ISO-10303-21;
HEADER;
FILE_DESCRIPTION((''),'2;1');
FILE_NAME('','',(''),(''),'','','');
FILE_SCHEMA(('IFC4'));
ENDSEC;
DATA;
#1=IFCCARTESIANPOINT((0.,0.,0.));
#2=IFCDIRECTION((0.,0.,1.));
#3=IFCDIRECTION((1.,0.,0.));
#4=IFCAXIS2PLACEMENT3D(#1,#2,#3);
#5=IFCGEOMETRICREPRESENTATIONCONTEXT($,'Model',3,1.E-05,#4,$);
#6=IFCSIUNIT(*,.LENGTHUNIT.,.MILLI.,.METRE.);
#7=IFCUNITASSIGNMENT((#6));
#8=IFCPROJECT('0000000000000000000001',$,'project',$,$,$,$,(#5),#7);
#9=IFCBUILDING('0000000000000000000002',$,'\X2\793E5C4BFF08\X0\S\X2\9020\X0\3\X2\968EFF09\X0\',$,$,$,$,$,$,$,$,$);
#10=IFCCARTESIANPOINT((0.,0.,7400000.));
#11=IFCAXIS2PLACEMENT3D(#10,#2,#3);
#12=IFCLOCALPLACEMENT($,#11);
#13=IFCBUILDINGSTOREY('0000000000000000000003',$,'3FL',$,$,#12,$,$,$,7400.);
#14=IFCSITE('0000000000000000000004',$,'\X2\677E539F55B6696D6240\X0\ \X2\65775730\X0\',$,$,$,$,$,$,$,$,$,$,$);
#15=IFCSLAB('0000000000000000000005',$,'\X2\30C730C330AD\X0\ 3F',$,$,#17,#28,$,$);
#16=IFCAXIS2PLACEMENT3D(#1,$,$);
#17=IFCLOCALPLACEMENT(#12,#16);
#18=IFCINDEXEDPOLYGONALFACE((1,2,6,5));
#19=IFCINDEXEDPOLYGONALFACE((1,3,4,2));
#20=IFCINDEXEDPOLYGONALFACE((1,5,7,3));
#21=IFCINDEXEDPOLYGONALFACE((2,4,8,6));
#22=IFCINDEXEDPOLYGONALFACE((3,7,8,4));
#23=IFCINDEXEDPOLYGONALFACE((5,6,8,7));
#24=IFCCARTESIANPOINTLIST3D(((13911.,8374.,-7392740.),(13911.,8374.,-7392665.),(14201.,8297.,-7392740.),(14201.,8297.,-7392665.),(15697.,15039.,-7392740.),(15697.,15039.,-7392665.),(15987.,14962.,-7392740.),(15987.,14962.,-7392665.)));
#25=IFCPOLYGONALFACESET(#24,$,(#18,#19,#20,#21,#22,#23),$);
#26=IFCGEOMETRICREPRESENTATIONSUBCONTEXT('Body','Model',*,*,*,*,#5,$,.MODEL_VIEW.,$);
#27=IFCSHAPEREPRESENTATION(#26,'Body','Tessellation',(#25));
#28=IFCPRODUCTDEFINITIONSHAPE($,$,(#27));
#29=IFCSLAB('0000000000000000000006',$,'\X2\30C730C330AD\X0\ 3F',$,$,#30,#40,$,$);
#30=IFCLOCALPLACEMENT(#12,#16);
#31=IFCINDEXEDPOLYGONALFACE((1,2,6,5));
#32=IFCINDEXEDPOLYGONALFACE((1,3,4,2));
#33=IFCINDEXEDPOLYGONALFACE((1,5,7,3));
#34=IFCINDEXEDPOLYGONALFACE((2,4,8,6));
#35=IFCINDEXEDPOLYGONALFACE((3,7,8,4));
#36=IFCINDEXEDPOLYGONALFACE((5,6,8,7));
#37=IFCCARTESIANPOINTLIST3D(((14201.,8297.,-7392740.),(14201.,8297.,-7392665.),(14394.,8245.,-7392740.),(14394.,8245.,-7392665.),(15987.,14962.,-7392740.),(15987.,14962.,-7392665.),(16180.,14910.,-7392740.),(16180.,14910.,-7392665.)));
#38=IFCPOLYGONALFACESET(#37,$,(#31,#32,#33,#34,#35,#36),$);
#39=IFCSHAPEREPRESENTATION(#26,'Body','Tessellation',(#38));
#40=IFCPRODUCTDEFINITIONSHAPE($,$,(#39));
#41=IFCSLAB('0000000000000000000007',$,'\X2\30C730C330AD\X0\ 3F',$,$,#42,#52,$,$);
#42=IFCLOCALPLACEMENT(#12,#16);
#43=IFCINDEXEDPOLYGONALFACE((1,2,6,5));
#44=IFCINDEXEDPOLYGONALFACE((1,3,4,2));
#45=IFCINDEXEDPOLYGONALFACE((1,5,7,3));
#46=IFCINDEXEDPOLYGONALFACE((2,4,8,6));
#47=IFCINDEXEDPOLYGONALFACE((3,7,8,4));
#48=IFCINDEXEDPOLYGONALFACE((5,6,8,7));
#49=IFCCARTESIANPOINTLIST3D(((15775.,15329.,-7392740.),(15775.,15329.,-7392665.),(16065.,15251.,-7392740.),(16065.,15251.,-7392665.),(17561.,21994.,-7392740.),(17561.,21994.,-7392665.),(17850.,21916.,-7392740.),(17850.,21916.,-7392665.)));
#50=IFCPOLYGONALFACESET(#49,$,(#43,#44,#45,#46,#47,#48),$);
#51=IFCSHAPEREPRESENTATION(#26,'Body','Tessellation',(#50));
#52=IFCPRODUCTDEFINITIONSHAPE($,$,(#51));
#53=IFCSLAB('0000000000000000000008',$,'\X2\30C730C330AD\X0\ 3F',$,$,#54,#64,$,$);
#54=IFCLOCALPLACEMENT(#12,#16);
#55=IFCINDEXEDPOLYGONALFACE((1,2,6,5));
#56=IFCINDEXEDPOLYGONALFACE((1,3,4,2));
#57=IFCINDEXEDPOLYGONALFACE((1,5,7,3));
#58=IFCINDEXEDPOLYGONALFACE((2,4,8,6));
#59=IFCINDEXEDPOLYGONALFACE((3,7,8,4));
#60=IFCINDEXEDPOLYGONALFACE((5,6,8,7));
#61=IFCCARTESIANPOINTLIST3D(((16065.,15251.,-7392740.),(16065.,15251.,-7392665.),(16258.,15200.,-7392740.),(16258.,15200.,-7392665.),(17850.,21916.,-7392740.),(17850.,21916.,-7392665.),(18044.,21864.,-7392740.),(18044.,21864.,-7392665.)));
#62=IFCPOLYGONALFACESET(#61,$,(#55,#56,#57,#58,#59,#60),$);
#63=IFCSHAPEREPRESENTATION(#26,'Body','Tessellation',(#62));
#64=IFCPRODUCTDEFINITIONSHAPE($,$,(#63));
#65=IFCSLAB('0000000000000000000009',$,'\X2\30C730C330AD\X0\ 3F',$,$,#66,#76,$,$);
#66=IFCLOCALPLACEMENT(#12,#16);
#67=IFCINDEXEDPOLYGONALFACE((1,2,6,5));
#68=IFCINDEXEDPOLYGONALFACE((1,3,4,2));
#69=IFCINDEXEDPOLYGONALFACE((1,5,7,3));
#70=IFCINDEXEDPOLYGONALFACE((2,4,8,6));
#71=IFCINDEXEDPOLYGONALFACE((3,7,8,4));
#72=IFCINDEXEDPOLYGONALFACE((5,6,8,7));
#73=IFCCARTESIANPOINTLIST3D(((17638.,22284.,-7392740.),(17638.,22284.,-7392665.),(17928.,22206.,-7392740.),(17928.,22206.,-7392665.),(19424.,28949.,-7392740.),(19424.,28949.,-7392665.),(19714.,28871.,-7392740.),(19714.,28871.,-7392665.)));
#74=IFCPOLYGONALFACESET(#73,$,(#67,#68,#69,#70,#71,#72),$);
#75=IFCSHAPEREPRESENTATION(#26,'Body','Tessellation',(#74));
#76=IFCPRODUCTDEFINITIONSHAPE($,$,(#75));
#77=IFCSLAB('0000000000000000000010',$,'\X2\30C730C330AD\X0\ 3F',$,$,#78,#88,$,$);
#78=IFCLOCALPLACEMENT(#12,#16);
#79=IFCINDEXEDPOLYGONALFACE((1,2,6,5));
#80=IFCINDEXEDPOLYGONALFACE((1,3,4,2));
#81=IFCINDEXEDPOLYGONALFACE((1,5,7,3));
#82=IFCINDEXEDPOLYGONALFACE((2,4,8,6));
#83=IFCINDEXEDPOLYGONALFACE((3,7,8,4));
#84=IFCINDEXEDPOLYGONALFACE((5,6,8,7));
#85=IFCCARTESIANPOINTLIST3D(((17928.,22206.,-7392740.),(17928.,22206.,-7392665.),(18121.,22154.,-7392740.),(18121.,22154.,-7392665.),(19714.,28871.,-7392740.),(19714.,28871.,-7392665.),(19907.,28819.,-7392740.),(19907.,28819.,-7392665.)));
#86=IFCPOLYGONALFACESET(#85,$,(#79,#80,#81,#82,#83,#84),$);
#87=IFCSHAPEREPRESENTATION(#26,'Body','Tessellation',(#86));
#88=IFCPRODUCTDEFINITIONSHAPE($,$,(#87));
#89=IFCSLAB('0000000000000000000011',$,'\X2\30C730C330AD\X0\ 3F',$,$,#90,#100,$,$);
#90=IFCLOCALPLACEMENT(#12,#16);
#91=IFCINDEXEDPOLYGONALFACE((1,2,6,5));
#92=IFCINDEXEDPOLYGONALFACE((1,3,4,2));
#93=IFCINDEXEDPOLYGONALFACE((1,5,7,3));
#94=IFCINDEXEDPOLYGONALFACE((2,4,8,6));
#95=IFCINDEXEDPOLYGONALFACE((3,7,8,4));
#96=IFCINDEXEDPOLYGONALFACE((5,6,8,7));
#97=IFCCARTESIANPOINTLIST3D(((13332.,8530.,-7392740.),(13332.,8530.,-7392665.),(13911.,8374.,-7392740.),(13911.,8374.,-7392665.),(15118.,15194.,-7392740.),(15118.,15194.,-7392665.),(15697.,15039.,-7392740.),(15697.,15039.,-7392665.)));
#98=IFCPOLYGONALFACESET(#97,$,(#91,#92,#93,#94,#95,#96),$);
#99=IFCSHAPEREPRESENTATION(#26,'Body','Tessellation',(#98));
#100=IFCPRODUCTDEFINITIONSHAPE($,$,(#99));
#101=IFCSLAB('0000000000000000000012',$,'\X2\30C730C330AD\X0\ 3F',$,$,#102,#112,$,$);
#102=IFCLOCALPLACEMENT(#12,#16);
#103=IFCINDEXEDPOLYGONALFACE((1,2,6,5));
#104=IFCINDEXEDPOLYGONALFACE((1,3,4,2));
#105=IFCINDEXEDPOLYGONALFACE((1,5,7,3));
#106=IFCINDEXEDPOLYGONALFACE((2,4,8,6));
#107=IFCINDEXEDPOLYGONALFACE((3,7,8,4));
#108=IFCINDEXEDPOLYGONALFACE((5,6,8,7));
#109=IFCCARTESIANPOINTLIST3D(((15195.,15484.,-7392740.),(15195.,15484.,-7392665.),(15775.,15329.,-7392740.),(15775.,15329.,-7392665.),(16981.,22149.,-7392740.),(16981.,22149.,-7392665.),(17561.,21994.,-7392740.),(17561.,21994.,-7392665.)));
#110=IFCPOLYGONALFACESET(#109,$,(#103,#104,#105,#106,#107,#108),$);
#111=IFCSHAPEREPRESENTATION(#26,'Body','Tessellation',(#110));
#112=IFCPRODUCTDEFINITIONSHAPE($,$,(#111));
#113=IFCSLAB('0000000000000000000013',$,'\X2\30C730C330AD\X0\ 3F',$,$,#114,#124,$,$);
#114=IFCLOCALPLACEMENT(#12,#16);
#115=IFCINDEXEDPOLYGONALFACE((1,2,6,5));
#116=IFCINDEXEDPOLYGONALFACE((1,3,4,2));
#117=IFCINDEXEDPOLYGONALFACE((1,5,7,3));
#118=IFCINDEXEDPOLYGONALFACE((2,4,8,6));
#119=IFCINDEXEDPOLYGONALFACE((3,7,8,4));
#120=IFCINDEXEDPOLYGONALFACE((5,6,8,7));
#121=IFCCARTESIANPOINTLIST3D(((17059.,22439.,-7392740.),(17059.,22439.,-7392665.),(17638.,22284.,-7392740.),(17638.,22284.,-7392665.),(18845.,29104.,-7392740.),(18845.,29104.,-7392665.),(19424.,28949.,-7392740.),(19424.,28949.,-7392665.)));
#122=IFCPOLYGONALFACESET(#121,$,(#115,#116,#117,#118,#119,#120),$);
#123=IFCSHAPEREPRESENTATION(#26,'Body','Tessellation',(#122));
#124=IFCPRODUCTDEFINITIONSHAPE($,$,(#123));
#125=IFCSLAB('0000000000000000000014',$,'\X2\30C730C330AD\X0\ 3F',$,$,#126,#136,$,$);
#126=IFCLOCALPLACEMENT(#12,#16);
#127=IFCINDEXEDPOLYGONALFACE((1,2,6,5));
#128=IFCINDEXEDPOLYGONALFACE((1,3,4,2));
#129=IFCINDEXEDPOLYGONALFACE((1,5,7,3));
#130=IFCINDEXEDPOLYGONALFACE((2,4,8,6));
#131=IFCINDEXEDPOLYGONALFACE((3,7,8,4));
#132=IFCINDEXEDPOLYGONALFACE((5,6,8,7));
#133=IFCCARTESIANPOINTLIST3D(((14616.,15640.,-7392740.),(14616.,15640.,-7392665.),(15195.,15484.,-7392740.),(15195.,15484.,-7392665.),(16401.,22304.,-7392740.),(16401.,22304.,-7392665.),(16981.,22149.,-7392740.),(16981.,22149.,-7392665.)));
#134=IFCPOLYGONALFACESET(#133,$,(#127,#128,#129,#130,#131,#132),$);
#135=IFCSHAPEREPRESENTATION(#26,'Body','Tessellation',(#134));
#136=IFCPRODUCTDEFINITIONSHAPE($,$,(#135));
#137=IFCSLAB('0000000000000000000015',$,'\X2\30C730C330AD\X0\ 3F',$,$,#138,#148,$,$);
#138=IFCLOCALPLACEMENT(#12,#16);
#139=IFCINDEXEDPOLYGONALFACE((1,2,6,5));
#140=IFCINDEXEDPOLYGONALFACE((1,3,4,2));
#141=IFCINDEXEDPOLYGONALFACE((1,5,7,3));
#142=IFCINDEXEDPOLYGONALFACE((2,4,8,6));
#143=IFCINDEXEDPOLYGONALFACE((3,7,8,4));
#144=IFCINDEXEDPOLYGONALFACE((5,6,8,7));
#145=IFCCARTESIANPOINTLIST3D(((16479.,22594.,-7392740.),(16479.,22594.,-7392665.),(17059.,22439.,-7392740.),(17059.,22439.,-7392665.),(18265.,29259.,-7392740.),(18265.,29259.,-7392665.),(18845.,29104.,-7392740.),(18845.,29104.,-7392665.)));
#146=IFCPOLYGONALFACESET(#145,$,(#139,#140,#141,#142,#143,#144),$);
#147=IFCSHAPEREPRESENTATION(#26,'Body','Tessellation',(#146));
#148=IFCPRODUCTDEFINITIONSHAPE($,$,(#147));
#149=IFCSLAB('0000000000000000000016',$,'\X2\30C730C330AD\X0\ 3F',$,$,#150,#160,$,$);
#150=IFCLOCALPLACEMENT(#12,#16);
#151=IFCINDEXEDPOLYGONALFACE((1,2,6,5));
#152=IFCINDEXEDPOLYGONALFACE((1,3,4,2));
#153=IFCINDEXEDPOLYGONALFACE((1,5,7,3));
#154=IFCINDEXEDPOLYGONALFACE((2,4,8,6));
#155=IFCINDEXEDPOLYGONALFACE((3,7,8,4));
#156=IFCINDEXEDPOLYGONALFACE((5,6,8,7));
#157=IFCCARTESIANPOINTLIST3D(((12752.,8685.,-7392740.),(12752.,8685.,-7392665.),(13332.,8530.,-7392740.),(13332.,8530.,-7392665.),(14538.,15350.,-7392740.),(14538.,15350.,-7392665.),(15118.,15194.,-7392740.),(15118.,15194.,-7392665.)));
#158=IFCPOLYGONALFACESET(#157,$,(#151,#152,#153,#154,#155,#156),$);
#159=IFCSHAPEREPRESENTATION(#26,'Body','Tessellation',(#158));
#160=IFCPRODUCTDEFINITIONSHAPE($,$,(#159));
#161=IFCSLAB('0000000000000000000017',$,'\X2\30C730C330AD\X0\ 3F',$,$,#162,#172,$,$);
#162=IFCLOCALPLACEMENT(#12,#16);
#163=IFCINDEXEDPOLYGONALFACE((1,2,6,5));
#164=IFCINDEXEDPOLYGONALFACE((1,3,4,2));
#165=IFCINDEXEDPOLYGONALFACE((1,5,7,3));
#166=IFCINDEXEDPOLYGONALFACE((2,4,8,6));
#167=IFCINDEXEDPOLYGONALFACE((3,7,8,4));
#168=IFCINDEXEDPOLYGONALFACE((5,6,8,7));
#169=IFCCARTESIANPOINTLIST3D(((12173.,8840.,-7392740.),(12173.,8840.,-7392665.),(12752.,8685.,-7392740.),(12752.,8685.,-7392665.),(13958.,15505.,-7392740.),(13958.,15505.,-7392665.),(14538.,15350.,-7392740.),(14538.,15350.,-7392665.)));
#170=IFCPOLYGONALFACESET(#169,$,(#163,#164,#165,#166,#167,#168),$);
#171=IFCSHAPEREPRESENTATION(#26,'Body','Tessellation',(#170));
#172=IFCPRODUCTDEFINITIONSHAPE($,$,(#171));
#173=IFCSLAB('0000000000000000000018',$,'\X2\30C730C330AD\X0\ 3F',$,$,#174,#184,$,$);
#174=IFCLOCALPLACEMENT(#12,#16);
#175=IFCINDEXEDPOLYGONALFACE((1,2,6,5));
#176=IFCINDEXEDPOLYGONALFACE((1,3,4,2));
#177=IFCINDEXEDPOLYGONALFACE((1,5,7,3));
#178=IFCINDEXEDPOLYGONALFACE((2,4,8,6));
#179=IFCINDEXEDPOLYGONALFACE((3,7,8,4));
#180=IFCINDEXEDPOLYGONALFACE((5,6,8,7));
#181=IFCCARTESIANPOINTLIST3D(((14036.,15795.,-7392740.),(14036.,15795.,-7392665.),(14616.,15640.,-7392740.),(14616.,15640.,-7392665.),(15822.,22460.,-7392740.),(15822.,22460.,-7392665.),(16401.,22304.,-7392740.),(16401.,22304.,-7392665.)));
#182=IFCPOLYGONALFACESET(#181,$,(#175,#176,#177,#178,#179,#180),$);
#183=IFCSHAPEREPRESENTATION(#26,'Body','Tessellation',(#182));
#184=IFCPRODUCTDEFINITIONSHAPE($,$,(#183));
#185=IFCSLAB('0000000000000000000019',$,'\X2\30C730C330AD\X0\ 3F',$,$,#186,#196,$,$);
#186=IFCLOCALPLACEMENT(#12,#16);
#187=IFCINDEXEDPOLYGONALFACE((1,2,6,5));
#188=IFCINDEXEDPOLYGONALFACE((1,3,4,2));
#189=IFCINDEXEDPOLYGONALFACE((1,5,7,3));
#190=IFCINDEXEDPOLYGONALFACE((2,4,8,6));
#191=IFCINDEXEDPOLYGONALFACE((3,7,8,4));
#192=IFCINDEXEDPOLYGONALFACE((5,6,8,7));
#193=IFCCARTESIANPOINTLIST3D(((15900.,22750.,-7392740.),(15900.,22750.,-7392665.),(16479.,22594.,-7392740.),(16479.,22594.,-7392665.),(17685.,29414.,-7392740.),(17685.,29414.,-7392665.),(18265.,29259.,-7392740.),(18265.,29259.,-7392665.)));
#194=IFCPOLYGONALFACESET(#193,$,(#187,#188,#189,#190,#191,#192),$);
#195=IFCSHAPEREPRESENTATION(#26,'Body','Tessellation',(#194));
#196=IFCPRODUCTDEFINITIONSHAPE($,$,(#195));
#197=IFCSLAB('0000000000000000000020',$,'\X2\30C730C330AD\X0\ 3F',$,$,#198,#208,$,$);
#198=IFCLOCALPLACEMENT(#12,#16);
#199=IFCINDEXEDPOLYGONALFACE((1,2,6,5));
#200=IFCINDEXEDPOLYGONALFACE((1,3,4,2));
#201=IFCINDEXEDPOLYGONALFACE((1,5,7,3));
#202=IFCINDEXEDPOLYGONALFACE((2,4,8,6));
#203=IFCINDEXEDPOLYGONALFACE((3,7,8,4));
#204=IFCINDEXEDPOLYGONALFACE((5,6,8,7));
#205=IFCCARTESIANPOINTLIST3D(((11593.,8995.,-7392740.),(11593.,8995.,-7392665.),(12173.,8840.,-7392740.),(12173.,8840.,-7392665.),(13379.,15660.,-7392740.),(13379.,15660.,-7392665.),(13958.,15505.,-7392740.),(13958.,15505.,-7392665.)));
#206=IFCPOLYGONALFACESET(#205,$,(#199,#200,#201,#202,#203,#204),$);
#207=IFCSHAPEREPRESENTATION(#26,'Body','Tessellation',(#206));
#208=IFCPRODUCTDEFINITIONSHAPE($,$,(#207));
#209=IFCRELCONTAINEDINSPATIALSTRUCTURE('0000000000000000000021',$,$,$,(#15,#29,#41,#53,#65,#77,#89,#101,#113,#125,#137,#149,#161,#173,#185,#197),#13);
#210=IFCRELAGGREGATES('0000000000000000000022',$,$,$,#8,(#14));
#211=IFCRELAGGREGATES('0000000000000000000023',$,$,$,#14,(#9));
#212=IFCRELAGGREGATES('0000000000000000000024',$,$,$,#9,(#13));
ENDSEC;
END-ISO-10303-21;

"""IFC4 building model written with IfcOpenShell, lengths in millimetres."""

from ifc_helpers import new_model, si_unit, frame, origin, origin_with_axes, place, context, subcontext, project, spatial, polyline, outline, extrude, element, save


model = new_model("IFC4")

# Units and contexts
model_context = context("Model", 3, precision=1e-05, world=origin_with_axes())
body_context = subcontext(model_context, "Body", "Model", "MODEL_VIEW")
ifc_project = project(units=[si_unit("LENGTHUNIT", "METRE", prefix="MILLI")], contexts=[model_context])

# Site, building, storey
site = spatial("IfcSite", under=ifc_project, Name="松原営業所 敷地")
building = spatial("IfcBuilding", under=site, Name="社屋（S造3階）")
storey_placement = place(None, frame((0.0, 0.0, 7400000.0), z_axis=(0.0, 0.0, 1.0), x_axis=(1.0, 0.0, 0.0)))
storey = spatial("IfcBuildingStorey", under=building, at=storey_placement, Name="3FL", Elevation=7400.0)

# Slabs
slab_1_placement = place(storey_placement, frame((0.0, 0.0, -7392740.0), z_axis=(0.0, 0.0, 1.0), x_axis=(1.0, 0.0, 0.0)))
element("IfcSlab", 1, at=slab_1_placement, inside=storey, Name="デッキ 3F", context=body_context, shape_type="SweptSolid", body=[
    extrude(outline(polyline([(14201.0, 8297.0), (15987.0, 14962.0), (15697.0, 15039.0), (13911.0, 8374.0), (14201.0, 8297.0)])), origin(), (0.0, 0.0, 1.0), 75.0),
])
slab_2_placement = place(storey_placement, frame((0.0, 0.0, -7392740.0), z_axis=(0.0, 0.0, 1.0), x_axis=(1.0, 0.0, 0.0)))
element("IfcSlab", 2, at=slab_2_placement, inside=storey, Name="デッキ 3F", context=body_context, shape_type="SweptSolid", body=[
    extrude(outline(polyline([(14201.0, 8297.0), (15987.0, 14962.0), (16180.0, 14910.0), (14394.0, 8245.0), (14201.0, 8297.0)])), origin(), (0.0, 0.0, 1.0), 75.0),
])
slab_3_placement = place(storey_placement, frame((0.0, 0.0, -7392740.0), z_axis=(0.0, 0.0, 1.0), x_axis=(1.0, 0.0, 0.0)))
element("IfcSlab", 3, at=slab_3_placement, inside=storey, Name="デッキ 3F", context=body_context, shape_type="SweptSolid", body=[
    extrude(outline(polyline([(16065.0, 15251.0), (17850.0, 21916.0), (17561.0, 21994.0), (15775.0, 15329.0), (16065.0, 15251.0)])), origin(), (0.0, 0.0, 1.0), 75.0),
])
slab_4_placement = place(storey_placement, frame((0.0, 0.0, -7392740.0), z_axis=(0.0, 0.0, 1.0), x_axis=(1.0, 0.0, 0.0)))
element("IfcSlab", 4, at=slab_4_placement, inside=storey, Name="デッキ 3F", context=body_context, shape_type="SweptSolid", body=[
    extrude(outline(polyline([(16065.0, 15251.0), (17850.0, 21916.0), (18044.0, 21864.0), (16258.0, 15200.0), (16065.0, 15251.0)])), origin(), (0.0, 0.0, 1.0), 75.0),
])
slab_5_placement = place(storey_placement, frame((0.0, 0.0, -7392740.0), z_axis=(0.0, 0.0, 1.0), x_axis=(1.0, 0.0, 0.0)))
element("IfcSlab", 5, at=slab_5_placement, inside=storey, Name="デッキ 3F", context=body_context, shape_type="SweptSolid", body=[
    extrude(outline(polyline([(17928.0, 22206.0), (19714.0, 28871.0), (19424.0, 28949.0), (17638.0, 22284.0), (17928.0, 22206.0)])), origin(), (0.0, 0.0, 1.0), 75.0),
])
slab_6_placement = place(storey_placement, frame((0.0, 0.0, -7392740.0), z_axis=(0.0, 0.0, 1.0), x_axis=(1.0, 0.0, 0.0)))
element("IfcSlab", 6, at=slab_6_placement, inside=storey, Name="デッキ 3F", context=body_context, shape_type="SweptSolid", body=[
    extrude(outline(polyline([(17928.0, 22206.0), (19714.0, 28871.0), (19907.0, 28819.0), (18121.0, 22154.0), (17928.0, 22206.0)])), origin(), (0.0, 0.0, 1.0), 75.0),
])
slab_7_placement = place(storey_placement, frame((0.0, 0.0, -7392740.0), z_axis=(0.0, 0.0, 1.0), x_axis=(1.0, 0.0, 0.0)))
element("IfcSlab", 7, at=slab_7_placement, inside=storey, Name="デッキ 3F", context=body_context, shape_type="SweptSolid", body=[
    extrude(outline(polyline([(13911.0, 8374.0), (15697.0, 15039.0), (15118.0, 15194.0), (13332.0, 8530.0), (13911.0, 8374.0)])), origin(), (0.0, 0.0, 1.0), 75.0),
])
slab_8_placement = place(storey_placement, frame((0.0, 0.0, -7392740.0), z_axis=(0.0, 0.0, 1.0), x_axis=(1.0, 0.0, 0.0)))
element("IfcSlab", 8, at=slab_8_placement, inside=storey, Name="デッキ 3F", context=body_context, shape_type="SweptSolid", body=[
    extrude(outline(polyline([(15775.0, 15329.0), (17561.0, 21994.0), (16981.0, 22149.0), (15195.0, 15484.0), (15775.0, 15329.0)])), origin(), (0.0, 0.0, 1.0), 75.0),
])
slab_9_placement = place(storey_placement, frame((0.0, 0.0, -7392740.0), z_axis=(0.0, 0.0, 1.0), x_axis=(1.0, 0.0, 0.0)))
element("IfcSlab", 9, at=slab_9_placement, inside=storey, Name="デッキ 3F", context=body_context, shape_type="SweptSolid", body=[
    extrude(outline(polyline([(17638.0, 22284.0), (19424.0, 28949.0), (18845.0, 29104.0), (17059.0, 22439.0), (17638.0, 22284.0)])), origin(), (0.0, 0.0, 1.0), 75.0),
])
slab_10_placement = place(storey_placement, frame((0.0, 0.0, -7392740.0), z_axis=(0.0, 0.0, 1.0), x_axis=(1.0, 0.0, 0.0)))
element("IfcSlab", 10, at=slab_10_placement, inside=storey, Name="デッキ 3F", context=body_context, shape_type="SweptSolid", body=[
    extrude(outline(polyline([(15195.0, 15484.0), (16981.0, 22149.0), (16401.0, 22304.0), (14616.0, 15640.0), (15195.0, 15484.0)])), origin(), (0.0, 0.0, 1.0), 75.0),
])
slab_11_placement = place(storey_placement, frame((0.0, 0.0, -7392740.0), z_axis=(0.0, 0.0, 1.0), x_axis=(1.0, 0.0, 0.0)))
element("IfcSlab", 11, at=slab_11_placement, inside=storey, Name="デッキ 3F", context=body_context, shape_type="SweptSolid", body=[
    extrude(outline(polyline([(17059.0, 22439.0), (18845.0, 29104.0), (18265.0, 29259.0), (16479.0, 22594.0), (17059.0, 22439.0)])), origin(), (0.0, 0.0, 1.0), 75.0),
])
slab_12_placement = place(storey_placement, frame((0.0, 0.0, -7392740.0), z_axis=(0.0, 0.0, 1.0), x_axis=(1.0, 0.0, 0.0)))
element("IfcSlab", 12, at=slab_12_placement, inside=storey, Name="デッキ 3F", context=body_context, shape_type="SweptSolid", body=[
    extrude(outline(polyline([(13332.0, 8530.0), (15118.0, 15194.0), (14538.0, 15350.0), (12752.0, 8685.0), (13332.0, 8530.0)])), origin(), (0.0, 0.0, 1.0), 75.0),
])
slab_13_placement = place(storey_placement, frame((0.0, 0.0, -7392740.0), z_axis=(0.0, 0.0, 1.0), x_axis=(1.0, 0.0, 0.0)))
element("IfcSlab", 13, at=slab_13_placement, inside=storey, Name="デッキ 3F", context=body_context, shape_type="SweptSolid", body=[
    extrude(outline(polyline([(12752.0, 8685.0), (14538.0, 15350.0), (13958.0, 15505.0), (12173.0, 8840.0), (12752.0, 8685.0)])), origin(), (0.0, 0.0, 1.0), 75.0),
])
slab_14_placement = place(storey_placement, frame((0.0, 0.0, -7392740.0), z_axis=(0.0, 0.0, 1.0), x_axis=(1.0, 0.0, 0.0)))
element("IfcSlab", 14, at=slab_14_placement, inside=storey, Name="デッキ 3F", context=body_context, shape_type="SweptSolid", body=[
    extrude(outline(polyline([(14616.0, 15640.0), (16401.0, 22304.0), (15822.0, 22460.0), (14036.0, 15795.0), (14616.0, 15640.0)])), origin(), (0.0, 0.0, 1.0), 75.0),
])
slab_15_placement = place(storey_placement, frame((0.0, 0.0, -7392740.0), z_axis=(0.0, 0.0, 1.0), x_axis=(1.0, 0.0, 0.0)))
element("IfcSlab", 15, at=slab_15_placement, inside=storey, Name="デッキ 3F", context=body_context, shape_type="SweptSolid", body=[
    extrude(outline(polyline([(16479.0, 22594.0), (18265.0, 29259.0), (17685.0, 29414.0), (15900.0, 22750.0), (16479.0, 22594.0)])), origin(), (0.0, 0.0, 1.0), 75.0),
])
slab_16_placement = place(storey_placement, frame((0.0, 0.0, -7392740.0), z_axis=(0.0, 0.0, 1.0), x_axis=(1.0, 0.0, 0.0)))
element("IfcSlab", 16, at=slab_16_placement, inside=storey, Name="デッキ 3F", context=body_context, shape_type="SweptSolid", body=[
    extrude(outline(polyline([(12173.0, 8840.0), (13958.0, 15505.0), (13379.0, 15660.0), (11593.0, 8995.0), (12173.0, 8840.0)])), origin(), (0.0, 0.0, 1.0), 75.0),
])

save(model, "model.ifc")
